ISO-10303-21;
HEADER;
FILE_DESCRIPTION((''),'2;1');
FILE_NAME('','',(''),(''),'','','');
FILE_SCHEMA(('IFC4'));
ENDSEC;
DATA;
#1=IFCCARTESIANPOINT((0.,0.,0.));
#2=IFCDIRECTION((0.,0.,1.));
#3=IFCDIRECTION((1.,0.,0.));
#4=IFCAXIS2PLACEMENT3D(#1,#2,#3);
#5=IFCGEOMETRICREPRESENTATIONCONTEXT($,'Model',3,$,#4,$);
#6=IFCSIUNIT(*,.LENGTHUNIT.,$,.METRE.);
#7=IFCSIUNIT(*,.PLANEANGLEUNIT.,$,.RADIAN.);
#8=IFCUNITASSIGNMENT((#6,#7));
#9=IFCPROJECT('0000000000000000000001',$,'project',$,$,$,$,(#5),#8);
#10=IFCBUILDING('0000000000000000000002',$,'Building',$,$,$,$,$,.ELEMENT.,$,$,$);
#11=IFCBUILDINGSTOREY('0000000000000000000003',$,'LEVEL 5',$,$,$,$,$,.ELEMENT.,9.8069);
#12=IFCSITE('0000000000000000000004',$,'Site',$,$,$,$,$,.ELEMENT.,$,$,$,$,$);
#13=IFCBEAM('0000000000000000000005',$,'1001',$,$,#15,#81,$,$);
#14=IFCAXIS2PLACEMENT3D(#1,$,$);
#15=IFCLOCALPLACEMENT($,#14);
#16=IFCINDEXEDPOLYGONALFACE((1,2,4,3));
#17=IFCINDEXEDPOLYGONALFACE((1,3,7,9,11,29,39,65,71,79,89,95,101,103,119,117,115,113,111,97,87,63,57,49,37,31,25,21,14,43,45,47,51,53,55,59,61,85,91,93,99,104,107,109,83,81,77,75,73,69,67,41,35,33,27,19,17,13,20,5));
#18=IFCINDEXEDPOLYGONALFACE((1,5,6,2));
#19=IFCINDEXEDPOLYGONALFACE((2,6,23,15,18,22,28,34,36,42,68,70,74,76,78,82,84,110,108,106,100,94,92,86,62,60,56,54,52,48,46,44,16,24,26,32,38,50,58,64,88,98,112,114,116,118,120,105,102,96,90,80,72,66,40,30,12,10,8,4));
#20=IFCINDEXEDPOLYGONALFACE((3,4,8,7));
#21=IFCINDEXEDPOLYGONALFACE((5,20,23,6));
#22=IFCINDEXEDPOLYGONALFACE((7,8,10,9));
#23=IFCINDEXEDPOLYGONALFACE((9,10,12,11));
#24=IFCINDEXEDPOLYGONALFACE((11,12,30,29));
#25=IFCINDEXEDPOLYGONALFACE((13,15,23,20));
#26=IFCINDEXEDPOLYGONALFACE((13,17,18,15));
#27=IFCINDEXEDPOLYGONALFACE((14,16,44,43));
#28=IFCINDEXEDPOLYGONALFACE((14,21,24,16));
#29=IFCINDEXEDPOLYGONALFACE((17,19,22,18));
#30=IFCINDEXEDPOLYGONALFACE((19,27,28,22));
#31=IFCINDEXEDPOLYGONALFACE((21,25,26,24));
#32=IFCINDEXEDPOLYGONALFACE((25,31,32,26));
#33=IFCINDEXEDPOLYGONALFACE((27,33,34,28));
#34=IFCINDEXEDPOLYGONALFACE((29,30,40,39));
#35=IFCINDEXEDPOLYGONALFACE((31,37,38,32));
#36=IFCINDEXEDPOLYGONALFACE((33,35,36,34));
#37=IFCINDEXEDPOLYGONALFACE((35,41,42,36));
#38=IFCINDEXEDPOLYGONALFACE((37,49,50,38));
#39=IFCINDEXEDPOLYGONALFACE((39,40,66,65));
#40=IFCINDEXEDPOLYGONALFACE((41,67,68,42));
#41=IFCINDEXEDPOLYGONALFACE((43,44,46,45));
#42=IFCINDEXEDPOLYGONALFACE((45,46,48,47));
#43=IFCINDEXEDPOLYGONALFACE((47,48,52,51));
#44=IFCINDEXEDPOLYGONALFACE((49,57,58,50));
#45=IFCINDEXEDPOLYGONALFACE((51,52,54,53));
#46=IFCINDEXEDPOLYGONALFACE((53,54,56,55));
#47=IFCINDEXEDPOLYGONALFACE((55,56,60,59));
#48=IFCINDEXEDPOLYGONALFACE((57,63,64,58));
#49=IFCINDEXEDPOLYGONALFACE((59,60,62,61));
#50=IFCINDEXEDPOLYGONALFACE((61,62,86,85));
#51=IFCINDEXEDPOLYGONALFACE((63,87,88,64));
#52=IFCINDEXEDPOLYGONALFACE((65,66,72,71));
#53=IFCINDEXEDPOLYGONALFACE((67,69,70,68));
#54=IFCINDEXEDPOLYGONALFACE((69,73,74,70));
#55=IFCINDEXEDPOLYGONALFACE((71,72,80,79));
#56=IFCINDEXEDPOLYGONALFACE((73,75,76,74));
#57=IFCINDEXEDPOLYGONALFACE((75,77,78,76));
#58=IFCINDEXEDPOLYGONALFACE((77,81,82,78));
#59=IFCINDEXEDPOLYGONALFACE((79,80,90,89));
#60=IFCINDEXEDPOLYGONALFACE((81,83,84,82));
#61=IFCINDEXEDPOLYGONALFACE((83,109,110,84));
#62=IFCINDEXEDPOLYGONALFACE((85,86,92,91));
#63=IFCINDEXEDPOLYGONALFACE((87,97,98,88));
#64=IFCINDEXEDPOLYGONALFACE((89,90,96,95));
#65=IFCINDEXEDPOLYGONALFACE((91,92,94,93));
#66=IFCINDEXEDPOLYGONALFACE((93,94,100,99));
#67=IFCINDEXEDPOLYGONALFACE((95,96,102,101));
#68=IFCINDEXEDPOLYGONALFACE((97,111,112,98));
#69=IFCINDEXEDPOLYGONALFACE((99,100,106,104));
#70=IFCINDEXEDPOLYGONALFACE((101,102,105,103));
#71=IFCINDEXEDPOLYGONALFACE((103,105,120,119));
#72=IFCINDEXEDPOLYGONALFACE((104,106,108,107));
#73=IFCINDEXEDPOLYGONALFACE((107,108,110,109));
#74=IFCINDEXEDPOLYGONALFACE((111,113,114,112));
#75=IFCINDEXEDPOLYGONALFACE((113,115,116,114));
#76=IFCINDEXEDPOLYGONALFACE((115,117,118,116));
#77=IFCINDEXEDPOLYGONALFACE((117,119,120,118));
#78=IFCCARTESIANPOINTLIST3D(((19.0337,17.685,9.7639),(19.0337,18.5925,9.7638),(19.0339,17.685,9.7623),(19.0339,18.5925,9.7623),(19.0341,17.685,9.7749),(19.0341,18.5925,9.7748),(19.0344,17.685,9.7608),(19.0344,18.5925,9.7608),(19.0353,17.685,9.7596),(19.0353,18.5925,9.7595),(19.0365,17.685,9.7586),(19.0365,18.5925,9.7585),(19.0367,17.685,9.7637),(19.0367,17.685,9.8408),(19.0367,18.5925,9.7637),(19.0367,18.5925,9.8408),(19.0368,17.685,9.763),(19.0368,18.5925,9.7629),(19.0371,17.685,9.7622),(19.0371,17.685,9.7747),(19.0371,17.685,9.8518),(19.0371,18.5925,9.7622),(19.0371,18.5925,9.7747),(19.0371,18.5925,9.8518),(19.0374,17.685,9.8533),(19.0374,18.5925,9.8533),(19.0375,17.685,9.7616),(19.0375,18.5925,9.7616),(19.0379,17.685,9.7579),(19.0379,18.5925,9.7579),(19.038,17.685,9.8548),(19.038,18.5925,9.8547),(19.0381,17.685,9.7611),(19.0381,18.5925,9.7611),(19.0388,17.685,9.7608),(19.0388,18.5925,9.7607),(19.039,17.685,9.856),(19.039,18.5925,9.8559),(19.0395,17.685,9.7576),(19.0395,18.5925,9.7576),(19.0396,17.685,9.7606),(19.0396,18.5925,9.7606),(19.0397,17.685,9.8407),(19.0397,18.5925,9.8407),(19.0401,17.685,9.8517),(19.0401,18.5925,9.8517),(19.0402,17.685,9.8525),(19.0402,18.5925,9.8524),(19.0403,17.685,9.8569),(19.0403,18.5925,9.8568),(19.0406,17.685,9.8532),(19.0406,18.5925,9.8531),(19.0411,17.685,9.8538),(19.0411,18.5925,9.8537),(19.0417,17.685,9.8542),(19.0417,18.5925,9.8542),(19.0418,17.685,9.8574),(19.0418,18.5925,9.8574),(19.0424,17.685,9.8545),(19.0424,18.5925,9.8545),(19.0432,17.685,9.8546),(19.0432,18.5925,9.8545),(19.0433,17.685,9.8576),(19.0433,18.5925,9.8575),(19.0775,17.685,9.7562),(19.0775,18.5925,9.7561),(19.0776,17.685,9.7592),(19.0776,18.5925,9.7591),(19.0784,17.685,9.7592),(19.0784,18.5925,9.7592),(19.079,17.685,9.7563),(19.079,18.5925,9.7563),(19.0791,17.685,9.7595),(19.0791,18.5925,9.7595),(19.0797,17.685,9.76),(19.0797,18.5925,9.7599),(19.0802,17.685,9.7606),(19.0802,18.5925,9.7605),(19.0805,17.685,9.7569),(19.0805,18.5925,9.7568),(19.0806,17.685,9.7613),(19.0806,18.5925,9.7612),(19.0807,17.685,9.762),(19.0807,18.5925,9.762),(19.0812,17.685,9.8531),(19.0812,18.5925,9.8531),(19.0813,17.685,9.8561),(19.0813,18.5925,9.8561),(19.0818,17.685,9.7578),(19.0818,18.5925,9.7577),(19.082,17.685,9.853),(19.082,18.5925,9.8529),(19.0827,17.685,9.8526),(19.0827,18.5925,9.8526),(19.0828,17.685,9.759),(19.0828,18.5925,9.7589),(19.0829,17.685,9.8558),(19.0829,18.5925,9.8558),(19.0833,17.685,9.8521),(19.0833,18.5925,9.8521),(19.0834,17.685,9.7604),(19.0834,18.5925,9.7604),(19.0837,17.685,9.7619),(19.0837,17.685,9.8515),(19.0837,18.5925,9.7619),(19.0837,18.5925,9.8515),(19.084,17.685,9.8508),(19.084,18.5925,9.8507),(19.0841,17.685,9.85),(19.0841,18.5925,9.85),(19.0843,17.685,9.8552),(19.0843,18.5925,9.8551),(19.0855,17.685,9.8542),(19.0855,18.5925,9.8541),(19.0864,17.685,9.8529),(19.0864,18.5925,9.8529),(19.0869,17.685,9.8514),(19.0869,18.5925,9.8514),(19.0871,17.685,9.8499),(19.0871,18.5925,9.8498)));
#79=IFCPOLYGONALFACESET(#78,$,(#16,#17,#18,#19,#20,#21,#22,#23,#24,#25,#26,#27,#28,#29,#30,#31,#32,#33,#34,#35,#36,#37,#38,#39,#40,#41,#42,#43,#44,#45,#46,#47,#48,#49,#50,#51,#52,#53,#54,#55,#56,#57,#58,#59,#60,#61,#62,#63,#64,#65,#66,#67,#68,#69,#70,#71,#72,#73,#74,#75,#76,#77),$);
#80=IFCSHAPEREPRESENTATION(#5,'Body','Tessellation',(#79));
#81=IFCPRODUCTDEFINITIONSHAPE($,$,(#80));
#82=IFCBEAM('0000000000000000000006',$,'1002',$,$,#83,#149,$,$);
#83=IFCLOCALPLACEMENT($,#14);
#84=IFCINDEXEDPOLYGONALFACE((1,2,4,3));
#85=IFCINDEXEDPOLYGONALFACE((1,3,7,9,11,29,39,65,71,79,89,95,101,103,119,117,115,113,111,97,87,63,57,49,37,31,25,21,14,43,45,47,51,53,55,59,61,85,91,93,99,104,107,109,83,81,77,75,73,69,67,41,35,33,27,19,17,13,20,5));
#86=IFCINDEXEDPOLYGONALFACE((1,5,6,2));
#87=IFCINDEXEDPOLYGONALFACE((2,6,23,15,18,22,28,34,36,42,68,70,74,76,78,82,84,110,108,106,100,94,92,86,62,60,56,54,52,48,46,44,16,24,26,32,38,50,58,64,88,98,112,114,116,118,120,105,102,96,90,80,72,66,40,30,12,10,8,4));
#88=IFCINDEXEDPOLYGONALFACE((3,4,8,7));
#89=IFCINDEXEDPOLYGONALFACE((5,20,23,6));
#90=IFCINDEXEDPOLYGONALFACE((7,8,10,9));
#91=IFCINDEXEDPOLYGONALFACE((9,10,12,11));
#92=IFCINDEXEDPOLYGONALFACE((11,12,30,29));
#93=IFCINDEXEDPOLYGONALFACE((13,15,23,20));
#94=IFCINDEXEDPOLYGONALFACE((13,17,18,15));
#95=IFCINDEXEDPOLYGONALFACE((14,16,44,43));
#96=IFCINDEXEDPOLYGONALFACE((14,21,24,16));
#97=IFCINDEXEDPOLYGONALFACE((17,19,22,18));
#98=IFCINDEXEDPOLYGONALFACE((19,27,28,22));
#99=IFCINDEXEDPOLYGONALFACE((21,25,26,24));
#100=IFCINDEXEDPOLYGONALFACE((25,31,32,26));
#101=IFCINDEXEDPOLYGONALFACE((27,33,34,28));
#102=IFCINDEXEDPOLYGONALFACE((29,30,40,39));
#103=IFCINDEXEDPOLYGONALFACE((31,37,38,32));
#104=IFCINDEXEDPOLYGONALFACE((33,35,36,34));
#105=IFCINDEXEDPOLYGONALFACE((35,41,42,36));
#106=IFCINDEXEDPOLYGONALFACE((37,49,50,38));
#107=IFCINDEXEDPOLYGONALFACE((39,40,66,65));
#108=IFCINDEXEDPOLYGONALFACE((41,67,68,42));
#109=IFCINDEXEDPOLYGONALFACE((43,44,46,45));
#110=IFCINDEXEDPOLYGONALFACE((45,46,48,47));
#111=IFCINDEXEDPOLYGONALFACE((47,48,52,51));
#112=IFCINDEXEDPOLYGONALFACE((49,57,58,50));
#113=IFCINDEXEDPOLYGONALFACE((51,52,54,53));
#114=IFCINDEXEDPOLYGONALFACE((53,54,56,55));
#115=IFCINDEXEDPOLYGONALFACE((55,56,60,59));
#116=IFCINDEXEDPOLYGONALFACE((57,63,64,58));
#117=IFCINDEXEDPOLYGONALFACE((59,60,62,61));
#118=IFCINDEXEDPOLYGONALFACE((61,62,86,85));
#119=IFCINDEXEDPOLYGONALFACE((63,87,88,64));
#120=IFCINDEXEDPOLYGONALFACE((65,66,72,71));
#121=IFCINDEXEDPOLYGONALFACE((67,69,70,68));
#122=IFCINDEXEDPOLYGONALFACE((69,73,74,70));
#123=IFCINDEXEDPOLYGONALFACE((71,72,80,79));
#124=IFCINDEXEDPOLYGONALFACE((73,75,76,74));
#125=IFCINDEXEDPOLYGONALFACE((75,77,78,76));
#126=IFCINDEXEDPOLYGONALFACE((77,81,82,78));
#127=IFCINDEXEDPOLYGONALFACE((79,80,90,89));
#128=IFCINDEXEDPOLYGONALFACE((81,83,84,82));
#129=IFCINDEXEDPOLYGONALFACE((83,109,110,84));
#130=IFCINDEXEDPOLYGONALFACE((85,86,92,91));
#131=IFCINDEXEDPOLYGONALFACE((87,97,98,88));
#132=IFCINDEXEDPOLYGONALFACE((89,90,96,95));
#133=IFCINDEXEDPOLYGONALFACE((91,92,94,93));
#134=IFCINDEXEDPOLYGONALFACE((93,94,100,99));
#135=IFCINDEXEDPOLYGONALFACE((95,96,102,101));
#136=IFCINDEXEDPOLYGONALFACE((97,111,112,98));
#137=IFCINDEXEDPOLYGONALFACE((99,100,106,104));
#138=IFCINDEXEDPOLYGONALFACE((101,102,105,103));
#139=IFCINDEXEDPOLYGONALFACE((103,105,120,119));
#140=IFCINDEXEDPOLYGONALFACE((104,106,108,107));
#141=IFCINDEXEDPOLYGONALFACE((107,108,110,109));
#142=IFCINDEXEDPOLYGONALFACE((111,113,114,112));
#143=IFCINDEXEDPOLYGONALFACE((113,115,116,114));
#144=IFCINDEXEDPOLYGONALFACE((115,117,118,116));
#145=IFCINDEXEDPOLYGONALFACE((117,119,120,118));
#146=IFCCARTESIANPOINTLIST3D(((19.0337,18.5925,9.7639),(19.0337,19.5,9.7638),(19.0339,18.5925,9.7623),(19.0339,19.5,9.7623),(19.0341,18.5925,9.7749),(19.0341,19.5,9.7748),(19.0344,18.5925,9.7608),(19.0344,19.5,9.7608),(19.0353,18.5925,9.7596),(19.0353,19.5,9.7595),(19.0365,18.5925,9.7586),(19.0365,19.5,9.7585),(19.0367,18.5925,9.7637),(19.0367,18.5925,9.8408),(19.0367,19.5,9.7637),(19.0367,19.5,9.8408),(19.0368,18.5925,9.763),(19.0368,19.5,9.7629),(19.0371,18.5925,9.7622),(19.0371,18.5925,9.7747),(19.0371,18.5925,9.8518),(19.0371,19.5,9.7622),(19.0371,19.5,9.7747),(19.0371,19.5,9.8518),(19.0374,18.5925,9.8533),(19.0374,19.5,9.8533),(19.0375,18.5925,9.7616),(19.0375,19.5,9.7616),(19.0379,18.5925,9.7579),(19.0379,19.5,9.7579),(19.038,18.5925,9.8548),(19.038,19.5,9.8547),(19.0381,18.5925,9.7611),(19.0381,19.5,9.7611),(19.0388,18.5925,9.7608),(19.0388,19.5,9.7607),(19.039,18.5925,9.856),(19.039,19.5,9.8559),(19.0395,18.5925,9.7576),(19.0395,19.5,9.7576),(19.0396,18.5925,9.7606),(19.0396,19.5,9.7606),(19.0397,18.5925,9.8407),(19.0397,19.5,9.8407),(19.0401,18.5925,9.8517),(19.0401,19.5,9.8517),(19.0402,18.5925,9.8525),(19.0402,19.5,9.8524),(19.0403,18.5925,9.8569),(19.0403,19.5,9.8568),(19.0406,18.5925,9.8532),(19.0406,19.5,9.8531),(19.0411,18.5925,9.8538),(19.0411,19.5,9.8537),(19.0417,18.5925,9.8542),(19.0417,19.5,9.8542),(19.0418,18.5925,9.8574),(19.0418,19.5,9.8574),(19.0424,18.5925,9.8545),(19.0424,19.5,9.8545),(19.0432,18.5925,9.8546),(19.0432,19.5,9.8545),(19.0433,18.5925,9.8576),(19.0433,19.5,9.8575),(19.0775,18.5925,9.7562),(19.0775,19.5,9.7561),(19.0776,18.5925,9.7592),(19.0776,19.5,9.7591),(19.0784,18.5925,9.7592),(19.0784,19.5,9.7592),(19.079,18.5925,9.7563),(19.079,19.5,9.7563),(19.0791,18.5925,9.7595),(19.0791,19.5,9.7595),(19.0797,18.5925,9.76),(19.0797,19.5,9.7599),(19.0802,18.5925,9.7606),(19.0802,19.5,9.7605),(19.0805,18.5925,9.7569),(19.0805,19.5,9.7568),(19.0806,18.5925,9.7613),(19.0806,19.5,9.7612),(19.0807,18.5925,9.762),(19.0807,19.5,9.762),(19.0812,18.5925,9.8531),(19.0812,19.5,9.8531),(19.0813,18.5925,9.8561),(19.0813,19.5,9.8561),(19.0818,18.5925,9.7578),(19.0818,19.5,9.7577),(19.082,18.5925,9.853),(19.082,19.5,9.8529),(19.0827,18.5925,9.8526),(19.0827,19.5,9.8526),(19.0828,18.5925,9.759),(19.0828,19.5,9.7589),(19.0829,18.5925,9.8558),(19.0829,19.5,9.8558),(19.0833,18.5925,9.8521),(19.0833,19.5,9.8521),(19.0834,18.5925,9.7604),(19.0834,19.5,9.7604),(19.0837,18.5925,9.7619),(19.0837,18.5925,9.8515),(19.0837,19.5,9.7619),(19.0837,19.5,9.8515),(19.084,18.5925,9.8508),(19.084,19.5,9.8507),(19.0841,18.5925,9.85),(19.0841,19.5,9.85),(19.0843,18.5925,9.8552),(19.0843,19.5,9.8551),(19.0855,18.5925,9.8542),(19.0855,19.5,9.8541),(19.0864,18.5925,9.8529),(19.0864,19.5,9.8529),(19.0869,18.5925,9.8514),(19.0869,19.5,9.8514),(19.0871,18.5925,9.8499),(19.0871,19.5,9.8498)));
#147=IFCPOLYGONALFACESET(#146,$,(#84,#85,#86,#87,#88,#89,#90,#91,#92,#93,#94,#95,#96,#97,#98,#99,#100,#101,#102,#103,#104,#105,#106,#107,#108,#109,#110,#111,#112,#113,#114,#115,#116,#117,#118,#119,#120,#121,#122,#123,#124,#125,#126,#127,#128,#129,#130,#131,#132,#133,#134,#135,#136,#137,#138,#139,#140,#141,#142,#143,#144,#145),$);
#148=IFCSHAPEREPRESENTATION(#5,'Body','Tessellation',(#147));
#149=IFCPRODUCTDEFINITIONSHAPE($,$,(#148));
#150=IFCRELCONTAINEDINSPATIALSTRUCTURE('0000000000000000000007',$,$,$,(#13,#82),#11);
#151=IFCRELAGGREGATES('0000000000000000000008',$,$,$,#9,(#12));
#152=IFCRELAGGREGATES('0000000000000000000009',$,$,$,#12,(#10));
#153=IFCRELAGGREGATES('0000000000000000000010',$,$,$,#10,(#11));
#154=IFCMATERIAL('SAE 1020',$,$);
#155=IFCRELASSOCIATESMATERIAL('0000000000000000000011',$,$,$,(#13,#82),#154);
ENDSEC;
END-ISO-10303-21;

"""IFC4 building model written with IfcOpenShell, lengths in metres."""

from ifc_helpers import new_model, si_unit, frame, origin_with_axes, origin_2d_with_axis, place, context, project, spatial, c_section, extrude, material, material_profile, profile_set, profile_usage, element, save


model = new_model("IFC4")

# Units and contexts
model_context = context("Model", 3, world=origin_with_axes())
ifc_project = project(units=[si_unit("LENGTHUNIT", "METRE"), si_unit("PLANEANGLEUNIT", "RADIAN")], contexts=[model_context])

# Site, building, storey
site = spatial("IfcSite", under=ifc_project, Name="Site", CompositionType="ELEMENT")
building = spatial("IfcBuilding", under=site, Name="Building", CompositionType="ELEMENT")
storey = spatial("IfcBuildingStorey", under=building, Name="LEVEL 5", CompositionType="ELEMENT", Elevation=9.8069)

# Beams
ifc_material = material(Name="SAE 1020")
ifc_material_profile_1 = material_profile(ifc_material, c_section(Depth=0.1, Width=0.05, WallThickness=0.003, Girth=0.017, InternalFilletRadius=0.003, at=origin_2d_with_axis()))
ifc_profile_set_1 = profile_set([ifc_material_profile_1])
ifc_profile_usage_1 = profile_usage(ifc_profile_set_1, cardinal=10)
beam_1_placement = place(None, frame((19.0604, 17.685, 9.8069), z_axis=(0.0, 1.0, -0.00003), x_axis=(-0.999256, 0.000001, 0.038562)))
element("IfcBeam", 1, at=beam_1_placement, inside=storey, material=ifc_profile_usage_1, Name="1001", context=model_context, shape_type="SweptSolid", body=[
    extrude(c_section(Depth=0.1, Width=0.05, WallThickness=0.003, Girth=0.017, InternalFilletRadius=0.003, at=origin_2d_with_axis()), origin_with_axes(), (0.0, 0.0, 1.0), 0.9075),
])
ifc_material_profile_2 = material_profile(ifc_material, c_section(Depth=0.1, Width=0.05, WallThickness=0.003, Girth=0.017, InternalFilletRadius=0.003, at=origin_2d_with_axis()))
ifc_profile_set_2 = profile_set([ifc_material_profile_2])
ifc_profile_usage_2 = profile_usage(ifc_profile_set_2, cardinal=10)
beam_2_placement = place(None, frame((19.0604, 18.5925, 9.8069), z_axis=(0.0, 1.0, -0.00003), x_axis=(-0.999256, 0.000001, 0.038562)))
element("IfcBeam", 2, at=beam_2_placement, inside=storey, material=ifc_profile_usage_2, Name="1002", context=model_context, shape_type="SweptSolid", body=[
    extrude(c_section(Depth=0.1, Width=0.05, WallThickness=0.003, Girth=0.017, InternalFilletRadius=0.003, at=origin_2d_with_axis()), origin_with_axes(), (0.0, 0.0, 1.0), 0.9075),
])

save(model, "model.ifc")
